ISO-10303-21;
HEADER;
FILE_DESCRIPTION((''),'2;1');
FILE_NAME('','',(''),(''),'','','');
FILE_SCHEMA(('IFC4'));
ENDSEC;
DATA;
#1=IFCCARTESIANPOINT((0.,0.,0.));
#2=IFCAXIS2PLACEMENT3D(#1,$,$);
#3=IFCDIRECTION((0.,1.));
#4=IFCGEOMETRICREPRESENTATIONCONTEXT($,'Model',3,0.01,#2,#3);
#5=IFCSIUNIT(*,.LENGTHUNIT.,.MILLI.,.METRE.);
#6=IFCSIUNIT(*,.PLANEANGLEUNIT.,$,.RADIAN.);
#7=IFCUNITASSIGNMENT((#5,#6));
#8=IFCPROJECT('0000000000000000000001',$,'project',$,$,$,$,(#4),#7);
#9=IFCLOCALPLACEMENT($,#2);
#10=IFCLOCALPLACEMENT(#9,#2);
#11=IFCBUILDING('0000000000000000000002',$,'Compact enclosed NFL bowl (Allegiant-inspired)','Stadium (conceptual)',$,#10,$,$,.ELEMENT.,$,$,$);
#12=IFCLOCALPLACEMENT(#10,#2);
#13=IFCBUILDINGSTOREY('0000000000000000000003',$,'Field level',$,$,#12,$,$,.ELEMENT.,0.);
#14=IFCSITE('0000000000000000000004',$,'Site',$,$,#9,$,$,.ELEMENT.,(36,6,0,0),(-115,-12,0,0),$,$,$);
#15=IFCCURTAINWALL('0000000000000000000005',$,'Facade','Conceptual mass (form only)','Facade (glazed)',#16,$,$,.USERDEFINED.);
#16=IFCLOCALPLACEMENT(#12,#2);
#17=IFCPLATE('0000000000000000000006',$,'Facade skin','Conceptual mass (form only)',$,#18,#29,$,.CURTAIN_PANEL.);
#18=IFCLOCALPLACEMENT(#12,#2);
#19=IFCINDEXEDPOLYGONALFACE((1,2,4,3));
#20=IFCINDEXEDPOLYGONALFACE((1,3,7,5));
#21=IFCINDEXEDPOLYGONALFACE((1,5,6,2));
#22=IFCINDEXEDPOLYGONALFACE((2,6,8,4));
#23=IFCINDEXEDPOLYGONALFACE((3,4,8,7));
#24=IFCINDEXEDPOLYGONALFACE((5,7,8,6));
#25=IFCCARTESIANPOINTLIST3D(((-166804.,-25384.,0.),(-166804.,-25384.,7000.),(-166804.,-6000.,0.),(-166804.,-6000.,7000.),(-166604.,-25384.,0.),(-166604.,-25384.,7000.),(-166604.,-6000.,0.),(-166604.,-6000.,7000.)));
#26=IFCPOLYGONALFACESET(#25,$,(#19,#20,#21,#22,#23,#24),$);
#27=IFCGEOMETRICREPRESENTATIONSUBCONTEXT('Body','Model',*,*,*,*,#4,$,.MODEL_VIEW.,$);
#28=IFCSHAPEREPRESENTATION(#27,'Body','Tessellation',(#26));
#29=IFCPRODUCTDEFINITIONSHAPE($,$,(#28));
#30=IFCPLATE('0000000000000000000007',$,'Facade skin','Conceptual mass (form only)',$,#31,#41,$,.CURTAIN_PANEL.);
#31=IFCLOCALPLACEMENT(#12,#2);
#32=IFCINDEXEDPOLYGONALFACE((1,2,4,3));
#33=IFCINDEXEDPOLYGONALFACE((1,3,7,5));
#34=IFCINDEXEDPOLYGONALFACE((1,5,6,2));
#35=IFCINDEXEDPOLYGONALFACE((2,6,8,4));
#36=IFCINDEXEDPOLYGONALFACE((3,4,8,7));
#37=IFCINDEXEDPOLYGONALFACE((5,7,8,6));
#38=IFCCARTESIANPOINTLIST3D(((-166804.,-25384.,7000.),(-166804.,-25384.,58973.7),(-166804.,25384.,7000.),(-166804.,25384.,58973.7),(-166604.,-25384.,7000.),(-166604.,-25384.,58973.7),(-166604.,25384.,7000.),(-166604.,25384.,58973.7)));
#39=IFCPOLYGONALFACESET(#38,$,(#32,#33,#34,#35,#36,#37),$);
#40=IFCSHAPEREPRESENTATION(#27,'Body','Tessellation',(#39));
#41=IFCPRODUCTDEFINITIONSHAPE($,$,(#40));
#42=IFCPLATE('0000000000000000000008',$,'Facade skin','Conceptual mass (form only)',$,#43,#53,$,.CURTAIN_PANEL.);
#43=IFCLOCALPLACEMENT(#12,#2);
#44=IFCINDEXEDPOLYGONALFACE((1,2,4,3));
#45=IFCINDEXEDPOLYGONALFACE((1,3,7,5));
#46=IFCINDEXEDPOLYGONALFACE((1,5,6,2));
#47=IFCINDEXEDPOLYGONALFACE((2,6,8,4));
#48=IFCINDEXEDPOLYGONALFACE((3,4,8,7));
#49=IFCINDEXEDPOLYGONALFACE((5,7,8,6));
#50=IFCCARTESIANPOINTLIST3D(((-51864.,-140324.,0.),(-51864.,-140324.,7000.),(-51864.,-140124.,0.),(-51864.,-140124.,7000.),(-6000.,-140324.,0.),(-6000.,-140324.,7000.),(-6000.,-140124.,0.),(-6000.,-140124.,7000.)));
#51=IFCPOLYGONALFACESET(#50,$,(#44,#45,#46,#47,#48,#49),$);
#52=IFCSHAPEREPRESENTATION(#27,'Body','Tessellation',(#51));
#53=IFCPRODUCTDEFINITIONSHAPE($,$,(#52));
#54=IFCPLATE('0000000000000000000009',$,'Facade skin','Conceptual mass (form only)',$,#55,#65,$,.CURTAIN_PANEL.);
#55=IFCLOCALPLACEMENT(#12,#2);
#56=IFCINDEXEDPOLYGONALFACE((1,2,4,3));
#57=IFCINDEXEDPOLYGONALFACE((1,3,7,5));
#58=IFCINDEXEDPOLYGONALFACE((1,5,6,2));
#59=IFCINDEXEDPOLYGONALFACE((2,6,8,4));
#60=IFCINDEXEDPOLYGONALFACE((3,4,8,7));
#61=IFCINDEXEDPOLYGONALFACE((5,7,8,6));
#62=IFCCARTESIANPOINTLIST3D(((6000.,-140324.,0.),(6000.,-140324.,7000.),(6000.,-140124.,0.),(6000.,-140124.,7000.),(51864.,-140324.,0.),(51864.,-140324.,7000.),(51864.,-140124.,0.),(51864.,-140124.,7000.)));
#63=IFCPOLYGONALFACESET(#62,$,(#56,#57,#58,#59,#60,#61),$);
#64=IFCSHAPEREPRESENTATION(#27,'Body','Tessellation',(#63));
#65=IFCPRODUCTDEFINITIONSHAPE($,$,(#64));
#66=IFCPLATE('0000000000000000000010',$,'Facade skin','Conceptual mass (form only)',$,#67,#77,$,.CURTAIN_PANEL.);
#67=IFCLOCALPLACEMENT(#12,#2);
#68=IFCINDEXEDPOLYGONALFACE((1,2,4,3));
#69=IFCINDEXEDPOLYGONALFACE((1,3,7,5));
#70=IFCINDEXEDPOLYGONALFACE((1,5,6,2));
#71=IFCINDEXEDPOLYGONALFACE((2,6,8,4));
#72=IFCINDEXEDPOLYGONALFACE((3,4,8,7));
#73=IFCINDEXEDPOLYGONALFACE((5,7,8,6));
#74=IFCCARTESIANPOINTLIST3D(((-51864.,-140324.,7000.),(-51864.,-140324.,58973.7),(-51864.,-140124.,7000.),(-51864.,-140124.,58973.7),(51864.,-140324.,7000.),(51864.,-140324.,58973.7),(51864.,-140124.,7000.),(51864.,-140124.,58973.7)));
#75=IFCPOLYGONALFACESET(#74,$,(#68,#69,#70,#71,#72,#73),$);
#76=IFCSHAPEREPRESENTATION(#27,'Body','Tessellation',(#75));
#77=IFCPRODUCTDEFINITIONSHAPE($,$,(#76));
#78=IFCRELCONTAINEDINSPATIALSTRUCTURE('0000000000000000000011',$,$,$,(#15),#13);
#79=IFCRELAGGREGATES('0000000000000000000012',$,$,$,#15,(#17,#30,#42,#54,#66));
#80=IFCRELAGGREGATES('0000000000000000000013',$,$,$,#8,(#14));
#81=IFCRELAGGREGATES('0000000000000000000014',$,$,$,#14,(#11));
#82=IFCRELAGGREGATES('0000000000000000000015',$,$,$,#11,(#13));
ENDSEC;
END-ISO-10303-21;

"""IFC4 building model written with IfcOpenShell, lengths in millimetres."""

from ifc_helpers import new_model, si_unit, direction, frame, origin, place, context, subcontext, project, spatial, line, indexed_curve, outline, extrude, element, aggregate, save


model = new_model("IFC4")

# Units and contexts
model_context = context("Model", 3, precision=0.01, world=origin(), true_north=direction((0.0, 1.0)))
body_context = subcontext(model_context, "Body", "Model", "MODEL_VIEW")
ifc_project = project(units=[si_unit("LENGTHUNIT", "METRE", prefix="MILLI"), si_unit("PLANEANGLEUNIT", "RADIAN")], contexts=[model_context])

# Site, building, storey
site_placement = place(None, origin())
site = spatial("IfcSite", under=ifc_project, at=site_placement, Name="Site", CompositionType="ELEMENT", RefLatitude=(36, 6, 0, 0), RefLongitude=(-115, -12, 0, 0))
building_placement = place(site_placement, origin())
building = spatial("IfcBuilding", under=site, at=building_placement, Name="Compact enclosed NFL bowl (Allegiant-inspired)", Description="Stadium (conceptual)", CompositionType="ELEMENT")
storey_placement = place(building_placement, origin())
storey = spatial("IfcBuildingStorey", under=building, at=storey_placement, Name="Field level", CompositionType="ELEMENT", Elevation=0.0)

# Curtain wall, plates
placement_1 = place(storey_placement, origin())
curtain_wall = element("IfcCurtainWall", 1, at=placement_1, inside=storey, Name="Facade", Description="Conceptual mass (form only)", ObjectType="Facade (glazed)", PredefinedType="USERDEFINED")
placement_2 = place(building_placement, frame((0.0, 0.0, 5510.0)))
placement_3 = place(placement_2, frame((0.0, 0.0, -5510.0)))
plate_1 = element("IfcPlate", 2, at=placement_1, Name="Facade skin", Description="Conceptual mass (form only)", PredefinedType="CURTAIN_PANEL", context=body_context, shape_type="SweptSolid", body=[
    extrude(outline(indexed_curve([(-166604.0, -6000.0), (-166604.0, -25384.0), (-166804.0, -25384.0), (-166804.0, -6000.0)], segments=[line(1, 2), line(2, 3), line(3, 4), line(4, 1)], self_intersect=False)), origin(), (0.0, 0.0, 1.0), 7000.0),
])
plate_2 = element("IfcPlate", 3, at=placement_3, Name="Facade skin", Description="Conceptual mass (form only)", PredefinedType="CURTAIN_PANEL", context=body_context, shape_type="SweptSolid", body=[
    extrude(outline(indexed_curve([(-166604.0, 25384.0), (-166604.0, -25384.0), (-166804.0, -25384.0), (-166804.0, 25384.0)], segments=[line(1, 2), line(2, 3), line(3, 4), line(4, 1)], self_intersect=False)), frame((0.0, 0.0, 7000.0)), (0.0, 0.0, 1.0), 51973.7),
])
plate_3 = element("IfcPlate", 4, at=placement_1, Name="Facade skin", Description="Conceptual mass (form only)", PredefinedType="CURTAIN_PANEL", context=body_context, shape_type="SweptSolid", body=[
    extrude(outline(indexed_curve([(-51864.0, -140124.0), (-6000.0, -140124.0), (-6000.0, -140324.0), (-51864.0, -140324.0)], segments=[line(1, 2), line(2, 3), line(3, 4), line(4, 1)], self_intersect=False)), origin(), (0.0, 0.0, 1.0), 7000.0),
])
plate_4 = element("IfcPlate", 5, at=placement_1, Name="Facade skin", Description="Conceptual mass (form only)", PredefinedType="CURTAIN_PANEL", context=body_context, shape_type="SweptSolid", body=[
    extrude(outline(indexed_curve([(6000.0, -140124.0), (51864.0, -140124.0), (51864.0, -140324.0), (6000.0, -140324.0)], segments=[line(1, 2), line(2, 3), line(3, 4), line(4, 1)], self_intersect=False)), origin(), (0.0, 0.0, 1.0), 7000.0),
])
plate_5 = element("IfcPlate", 6, at=placement_3, Name="Facade skin", Description="Conceptual mass (form only)", PredefinedType="CURTAIN_PANEL", context=body_context, shape_type="SweptSolid", body=[
    extrude(outline(indexed_curve([(-51864.0, -140124.0), (51864.0, -140124.0), (51864.0, -140324.0), (-51864.0, -140324.0)], segments=[line(1, 2), line(2, 3), line(3, 4), line(4, 1)], self_intersect=False)), frame((0.0, 0.0, 7000.0)), (0.0, 0.0, 1.0), 51973.7),
])
aggregate(curtain_wall, [plate_1, plate_2, plate_3, plate_4, plate_5])

save(model, "model.ifc")
